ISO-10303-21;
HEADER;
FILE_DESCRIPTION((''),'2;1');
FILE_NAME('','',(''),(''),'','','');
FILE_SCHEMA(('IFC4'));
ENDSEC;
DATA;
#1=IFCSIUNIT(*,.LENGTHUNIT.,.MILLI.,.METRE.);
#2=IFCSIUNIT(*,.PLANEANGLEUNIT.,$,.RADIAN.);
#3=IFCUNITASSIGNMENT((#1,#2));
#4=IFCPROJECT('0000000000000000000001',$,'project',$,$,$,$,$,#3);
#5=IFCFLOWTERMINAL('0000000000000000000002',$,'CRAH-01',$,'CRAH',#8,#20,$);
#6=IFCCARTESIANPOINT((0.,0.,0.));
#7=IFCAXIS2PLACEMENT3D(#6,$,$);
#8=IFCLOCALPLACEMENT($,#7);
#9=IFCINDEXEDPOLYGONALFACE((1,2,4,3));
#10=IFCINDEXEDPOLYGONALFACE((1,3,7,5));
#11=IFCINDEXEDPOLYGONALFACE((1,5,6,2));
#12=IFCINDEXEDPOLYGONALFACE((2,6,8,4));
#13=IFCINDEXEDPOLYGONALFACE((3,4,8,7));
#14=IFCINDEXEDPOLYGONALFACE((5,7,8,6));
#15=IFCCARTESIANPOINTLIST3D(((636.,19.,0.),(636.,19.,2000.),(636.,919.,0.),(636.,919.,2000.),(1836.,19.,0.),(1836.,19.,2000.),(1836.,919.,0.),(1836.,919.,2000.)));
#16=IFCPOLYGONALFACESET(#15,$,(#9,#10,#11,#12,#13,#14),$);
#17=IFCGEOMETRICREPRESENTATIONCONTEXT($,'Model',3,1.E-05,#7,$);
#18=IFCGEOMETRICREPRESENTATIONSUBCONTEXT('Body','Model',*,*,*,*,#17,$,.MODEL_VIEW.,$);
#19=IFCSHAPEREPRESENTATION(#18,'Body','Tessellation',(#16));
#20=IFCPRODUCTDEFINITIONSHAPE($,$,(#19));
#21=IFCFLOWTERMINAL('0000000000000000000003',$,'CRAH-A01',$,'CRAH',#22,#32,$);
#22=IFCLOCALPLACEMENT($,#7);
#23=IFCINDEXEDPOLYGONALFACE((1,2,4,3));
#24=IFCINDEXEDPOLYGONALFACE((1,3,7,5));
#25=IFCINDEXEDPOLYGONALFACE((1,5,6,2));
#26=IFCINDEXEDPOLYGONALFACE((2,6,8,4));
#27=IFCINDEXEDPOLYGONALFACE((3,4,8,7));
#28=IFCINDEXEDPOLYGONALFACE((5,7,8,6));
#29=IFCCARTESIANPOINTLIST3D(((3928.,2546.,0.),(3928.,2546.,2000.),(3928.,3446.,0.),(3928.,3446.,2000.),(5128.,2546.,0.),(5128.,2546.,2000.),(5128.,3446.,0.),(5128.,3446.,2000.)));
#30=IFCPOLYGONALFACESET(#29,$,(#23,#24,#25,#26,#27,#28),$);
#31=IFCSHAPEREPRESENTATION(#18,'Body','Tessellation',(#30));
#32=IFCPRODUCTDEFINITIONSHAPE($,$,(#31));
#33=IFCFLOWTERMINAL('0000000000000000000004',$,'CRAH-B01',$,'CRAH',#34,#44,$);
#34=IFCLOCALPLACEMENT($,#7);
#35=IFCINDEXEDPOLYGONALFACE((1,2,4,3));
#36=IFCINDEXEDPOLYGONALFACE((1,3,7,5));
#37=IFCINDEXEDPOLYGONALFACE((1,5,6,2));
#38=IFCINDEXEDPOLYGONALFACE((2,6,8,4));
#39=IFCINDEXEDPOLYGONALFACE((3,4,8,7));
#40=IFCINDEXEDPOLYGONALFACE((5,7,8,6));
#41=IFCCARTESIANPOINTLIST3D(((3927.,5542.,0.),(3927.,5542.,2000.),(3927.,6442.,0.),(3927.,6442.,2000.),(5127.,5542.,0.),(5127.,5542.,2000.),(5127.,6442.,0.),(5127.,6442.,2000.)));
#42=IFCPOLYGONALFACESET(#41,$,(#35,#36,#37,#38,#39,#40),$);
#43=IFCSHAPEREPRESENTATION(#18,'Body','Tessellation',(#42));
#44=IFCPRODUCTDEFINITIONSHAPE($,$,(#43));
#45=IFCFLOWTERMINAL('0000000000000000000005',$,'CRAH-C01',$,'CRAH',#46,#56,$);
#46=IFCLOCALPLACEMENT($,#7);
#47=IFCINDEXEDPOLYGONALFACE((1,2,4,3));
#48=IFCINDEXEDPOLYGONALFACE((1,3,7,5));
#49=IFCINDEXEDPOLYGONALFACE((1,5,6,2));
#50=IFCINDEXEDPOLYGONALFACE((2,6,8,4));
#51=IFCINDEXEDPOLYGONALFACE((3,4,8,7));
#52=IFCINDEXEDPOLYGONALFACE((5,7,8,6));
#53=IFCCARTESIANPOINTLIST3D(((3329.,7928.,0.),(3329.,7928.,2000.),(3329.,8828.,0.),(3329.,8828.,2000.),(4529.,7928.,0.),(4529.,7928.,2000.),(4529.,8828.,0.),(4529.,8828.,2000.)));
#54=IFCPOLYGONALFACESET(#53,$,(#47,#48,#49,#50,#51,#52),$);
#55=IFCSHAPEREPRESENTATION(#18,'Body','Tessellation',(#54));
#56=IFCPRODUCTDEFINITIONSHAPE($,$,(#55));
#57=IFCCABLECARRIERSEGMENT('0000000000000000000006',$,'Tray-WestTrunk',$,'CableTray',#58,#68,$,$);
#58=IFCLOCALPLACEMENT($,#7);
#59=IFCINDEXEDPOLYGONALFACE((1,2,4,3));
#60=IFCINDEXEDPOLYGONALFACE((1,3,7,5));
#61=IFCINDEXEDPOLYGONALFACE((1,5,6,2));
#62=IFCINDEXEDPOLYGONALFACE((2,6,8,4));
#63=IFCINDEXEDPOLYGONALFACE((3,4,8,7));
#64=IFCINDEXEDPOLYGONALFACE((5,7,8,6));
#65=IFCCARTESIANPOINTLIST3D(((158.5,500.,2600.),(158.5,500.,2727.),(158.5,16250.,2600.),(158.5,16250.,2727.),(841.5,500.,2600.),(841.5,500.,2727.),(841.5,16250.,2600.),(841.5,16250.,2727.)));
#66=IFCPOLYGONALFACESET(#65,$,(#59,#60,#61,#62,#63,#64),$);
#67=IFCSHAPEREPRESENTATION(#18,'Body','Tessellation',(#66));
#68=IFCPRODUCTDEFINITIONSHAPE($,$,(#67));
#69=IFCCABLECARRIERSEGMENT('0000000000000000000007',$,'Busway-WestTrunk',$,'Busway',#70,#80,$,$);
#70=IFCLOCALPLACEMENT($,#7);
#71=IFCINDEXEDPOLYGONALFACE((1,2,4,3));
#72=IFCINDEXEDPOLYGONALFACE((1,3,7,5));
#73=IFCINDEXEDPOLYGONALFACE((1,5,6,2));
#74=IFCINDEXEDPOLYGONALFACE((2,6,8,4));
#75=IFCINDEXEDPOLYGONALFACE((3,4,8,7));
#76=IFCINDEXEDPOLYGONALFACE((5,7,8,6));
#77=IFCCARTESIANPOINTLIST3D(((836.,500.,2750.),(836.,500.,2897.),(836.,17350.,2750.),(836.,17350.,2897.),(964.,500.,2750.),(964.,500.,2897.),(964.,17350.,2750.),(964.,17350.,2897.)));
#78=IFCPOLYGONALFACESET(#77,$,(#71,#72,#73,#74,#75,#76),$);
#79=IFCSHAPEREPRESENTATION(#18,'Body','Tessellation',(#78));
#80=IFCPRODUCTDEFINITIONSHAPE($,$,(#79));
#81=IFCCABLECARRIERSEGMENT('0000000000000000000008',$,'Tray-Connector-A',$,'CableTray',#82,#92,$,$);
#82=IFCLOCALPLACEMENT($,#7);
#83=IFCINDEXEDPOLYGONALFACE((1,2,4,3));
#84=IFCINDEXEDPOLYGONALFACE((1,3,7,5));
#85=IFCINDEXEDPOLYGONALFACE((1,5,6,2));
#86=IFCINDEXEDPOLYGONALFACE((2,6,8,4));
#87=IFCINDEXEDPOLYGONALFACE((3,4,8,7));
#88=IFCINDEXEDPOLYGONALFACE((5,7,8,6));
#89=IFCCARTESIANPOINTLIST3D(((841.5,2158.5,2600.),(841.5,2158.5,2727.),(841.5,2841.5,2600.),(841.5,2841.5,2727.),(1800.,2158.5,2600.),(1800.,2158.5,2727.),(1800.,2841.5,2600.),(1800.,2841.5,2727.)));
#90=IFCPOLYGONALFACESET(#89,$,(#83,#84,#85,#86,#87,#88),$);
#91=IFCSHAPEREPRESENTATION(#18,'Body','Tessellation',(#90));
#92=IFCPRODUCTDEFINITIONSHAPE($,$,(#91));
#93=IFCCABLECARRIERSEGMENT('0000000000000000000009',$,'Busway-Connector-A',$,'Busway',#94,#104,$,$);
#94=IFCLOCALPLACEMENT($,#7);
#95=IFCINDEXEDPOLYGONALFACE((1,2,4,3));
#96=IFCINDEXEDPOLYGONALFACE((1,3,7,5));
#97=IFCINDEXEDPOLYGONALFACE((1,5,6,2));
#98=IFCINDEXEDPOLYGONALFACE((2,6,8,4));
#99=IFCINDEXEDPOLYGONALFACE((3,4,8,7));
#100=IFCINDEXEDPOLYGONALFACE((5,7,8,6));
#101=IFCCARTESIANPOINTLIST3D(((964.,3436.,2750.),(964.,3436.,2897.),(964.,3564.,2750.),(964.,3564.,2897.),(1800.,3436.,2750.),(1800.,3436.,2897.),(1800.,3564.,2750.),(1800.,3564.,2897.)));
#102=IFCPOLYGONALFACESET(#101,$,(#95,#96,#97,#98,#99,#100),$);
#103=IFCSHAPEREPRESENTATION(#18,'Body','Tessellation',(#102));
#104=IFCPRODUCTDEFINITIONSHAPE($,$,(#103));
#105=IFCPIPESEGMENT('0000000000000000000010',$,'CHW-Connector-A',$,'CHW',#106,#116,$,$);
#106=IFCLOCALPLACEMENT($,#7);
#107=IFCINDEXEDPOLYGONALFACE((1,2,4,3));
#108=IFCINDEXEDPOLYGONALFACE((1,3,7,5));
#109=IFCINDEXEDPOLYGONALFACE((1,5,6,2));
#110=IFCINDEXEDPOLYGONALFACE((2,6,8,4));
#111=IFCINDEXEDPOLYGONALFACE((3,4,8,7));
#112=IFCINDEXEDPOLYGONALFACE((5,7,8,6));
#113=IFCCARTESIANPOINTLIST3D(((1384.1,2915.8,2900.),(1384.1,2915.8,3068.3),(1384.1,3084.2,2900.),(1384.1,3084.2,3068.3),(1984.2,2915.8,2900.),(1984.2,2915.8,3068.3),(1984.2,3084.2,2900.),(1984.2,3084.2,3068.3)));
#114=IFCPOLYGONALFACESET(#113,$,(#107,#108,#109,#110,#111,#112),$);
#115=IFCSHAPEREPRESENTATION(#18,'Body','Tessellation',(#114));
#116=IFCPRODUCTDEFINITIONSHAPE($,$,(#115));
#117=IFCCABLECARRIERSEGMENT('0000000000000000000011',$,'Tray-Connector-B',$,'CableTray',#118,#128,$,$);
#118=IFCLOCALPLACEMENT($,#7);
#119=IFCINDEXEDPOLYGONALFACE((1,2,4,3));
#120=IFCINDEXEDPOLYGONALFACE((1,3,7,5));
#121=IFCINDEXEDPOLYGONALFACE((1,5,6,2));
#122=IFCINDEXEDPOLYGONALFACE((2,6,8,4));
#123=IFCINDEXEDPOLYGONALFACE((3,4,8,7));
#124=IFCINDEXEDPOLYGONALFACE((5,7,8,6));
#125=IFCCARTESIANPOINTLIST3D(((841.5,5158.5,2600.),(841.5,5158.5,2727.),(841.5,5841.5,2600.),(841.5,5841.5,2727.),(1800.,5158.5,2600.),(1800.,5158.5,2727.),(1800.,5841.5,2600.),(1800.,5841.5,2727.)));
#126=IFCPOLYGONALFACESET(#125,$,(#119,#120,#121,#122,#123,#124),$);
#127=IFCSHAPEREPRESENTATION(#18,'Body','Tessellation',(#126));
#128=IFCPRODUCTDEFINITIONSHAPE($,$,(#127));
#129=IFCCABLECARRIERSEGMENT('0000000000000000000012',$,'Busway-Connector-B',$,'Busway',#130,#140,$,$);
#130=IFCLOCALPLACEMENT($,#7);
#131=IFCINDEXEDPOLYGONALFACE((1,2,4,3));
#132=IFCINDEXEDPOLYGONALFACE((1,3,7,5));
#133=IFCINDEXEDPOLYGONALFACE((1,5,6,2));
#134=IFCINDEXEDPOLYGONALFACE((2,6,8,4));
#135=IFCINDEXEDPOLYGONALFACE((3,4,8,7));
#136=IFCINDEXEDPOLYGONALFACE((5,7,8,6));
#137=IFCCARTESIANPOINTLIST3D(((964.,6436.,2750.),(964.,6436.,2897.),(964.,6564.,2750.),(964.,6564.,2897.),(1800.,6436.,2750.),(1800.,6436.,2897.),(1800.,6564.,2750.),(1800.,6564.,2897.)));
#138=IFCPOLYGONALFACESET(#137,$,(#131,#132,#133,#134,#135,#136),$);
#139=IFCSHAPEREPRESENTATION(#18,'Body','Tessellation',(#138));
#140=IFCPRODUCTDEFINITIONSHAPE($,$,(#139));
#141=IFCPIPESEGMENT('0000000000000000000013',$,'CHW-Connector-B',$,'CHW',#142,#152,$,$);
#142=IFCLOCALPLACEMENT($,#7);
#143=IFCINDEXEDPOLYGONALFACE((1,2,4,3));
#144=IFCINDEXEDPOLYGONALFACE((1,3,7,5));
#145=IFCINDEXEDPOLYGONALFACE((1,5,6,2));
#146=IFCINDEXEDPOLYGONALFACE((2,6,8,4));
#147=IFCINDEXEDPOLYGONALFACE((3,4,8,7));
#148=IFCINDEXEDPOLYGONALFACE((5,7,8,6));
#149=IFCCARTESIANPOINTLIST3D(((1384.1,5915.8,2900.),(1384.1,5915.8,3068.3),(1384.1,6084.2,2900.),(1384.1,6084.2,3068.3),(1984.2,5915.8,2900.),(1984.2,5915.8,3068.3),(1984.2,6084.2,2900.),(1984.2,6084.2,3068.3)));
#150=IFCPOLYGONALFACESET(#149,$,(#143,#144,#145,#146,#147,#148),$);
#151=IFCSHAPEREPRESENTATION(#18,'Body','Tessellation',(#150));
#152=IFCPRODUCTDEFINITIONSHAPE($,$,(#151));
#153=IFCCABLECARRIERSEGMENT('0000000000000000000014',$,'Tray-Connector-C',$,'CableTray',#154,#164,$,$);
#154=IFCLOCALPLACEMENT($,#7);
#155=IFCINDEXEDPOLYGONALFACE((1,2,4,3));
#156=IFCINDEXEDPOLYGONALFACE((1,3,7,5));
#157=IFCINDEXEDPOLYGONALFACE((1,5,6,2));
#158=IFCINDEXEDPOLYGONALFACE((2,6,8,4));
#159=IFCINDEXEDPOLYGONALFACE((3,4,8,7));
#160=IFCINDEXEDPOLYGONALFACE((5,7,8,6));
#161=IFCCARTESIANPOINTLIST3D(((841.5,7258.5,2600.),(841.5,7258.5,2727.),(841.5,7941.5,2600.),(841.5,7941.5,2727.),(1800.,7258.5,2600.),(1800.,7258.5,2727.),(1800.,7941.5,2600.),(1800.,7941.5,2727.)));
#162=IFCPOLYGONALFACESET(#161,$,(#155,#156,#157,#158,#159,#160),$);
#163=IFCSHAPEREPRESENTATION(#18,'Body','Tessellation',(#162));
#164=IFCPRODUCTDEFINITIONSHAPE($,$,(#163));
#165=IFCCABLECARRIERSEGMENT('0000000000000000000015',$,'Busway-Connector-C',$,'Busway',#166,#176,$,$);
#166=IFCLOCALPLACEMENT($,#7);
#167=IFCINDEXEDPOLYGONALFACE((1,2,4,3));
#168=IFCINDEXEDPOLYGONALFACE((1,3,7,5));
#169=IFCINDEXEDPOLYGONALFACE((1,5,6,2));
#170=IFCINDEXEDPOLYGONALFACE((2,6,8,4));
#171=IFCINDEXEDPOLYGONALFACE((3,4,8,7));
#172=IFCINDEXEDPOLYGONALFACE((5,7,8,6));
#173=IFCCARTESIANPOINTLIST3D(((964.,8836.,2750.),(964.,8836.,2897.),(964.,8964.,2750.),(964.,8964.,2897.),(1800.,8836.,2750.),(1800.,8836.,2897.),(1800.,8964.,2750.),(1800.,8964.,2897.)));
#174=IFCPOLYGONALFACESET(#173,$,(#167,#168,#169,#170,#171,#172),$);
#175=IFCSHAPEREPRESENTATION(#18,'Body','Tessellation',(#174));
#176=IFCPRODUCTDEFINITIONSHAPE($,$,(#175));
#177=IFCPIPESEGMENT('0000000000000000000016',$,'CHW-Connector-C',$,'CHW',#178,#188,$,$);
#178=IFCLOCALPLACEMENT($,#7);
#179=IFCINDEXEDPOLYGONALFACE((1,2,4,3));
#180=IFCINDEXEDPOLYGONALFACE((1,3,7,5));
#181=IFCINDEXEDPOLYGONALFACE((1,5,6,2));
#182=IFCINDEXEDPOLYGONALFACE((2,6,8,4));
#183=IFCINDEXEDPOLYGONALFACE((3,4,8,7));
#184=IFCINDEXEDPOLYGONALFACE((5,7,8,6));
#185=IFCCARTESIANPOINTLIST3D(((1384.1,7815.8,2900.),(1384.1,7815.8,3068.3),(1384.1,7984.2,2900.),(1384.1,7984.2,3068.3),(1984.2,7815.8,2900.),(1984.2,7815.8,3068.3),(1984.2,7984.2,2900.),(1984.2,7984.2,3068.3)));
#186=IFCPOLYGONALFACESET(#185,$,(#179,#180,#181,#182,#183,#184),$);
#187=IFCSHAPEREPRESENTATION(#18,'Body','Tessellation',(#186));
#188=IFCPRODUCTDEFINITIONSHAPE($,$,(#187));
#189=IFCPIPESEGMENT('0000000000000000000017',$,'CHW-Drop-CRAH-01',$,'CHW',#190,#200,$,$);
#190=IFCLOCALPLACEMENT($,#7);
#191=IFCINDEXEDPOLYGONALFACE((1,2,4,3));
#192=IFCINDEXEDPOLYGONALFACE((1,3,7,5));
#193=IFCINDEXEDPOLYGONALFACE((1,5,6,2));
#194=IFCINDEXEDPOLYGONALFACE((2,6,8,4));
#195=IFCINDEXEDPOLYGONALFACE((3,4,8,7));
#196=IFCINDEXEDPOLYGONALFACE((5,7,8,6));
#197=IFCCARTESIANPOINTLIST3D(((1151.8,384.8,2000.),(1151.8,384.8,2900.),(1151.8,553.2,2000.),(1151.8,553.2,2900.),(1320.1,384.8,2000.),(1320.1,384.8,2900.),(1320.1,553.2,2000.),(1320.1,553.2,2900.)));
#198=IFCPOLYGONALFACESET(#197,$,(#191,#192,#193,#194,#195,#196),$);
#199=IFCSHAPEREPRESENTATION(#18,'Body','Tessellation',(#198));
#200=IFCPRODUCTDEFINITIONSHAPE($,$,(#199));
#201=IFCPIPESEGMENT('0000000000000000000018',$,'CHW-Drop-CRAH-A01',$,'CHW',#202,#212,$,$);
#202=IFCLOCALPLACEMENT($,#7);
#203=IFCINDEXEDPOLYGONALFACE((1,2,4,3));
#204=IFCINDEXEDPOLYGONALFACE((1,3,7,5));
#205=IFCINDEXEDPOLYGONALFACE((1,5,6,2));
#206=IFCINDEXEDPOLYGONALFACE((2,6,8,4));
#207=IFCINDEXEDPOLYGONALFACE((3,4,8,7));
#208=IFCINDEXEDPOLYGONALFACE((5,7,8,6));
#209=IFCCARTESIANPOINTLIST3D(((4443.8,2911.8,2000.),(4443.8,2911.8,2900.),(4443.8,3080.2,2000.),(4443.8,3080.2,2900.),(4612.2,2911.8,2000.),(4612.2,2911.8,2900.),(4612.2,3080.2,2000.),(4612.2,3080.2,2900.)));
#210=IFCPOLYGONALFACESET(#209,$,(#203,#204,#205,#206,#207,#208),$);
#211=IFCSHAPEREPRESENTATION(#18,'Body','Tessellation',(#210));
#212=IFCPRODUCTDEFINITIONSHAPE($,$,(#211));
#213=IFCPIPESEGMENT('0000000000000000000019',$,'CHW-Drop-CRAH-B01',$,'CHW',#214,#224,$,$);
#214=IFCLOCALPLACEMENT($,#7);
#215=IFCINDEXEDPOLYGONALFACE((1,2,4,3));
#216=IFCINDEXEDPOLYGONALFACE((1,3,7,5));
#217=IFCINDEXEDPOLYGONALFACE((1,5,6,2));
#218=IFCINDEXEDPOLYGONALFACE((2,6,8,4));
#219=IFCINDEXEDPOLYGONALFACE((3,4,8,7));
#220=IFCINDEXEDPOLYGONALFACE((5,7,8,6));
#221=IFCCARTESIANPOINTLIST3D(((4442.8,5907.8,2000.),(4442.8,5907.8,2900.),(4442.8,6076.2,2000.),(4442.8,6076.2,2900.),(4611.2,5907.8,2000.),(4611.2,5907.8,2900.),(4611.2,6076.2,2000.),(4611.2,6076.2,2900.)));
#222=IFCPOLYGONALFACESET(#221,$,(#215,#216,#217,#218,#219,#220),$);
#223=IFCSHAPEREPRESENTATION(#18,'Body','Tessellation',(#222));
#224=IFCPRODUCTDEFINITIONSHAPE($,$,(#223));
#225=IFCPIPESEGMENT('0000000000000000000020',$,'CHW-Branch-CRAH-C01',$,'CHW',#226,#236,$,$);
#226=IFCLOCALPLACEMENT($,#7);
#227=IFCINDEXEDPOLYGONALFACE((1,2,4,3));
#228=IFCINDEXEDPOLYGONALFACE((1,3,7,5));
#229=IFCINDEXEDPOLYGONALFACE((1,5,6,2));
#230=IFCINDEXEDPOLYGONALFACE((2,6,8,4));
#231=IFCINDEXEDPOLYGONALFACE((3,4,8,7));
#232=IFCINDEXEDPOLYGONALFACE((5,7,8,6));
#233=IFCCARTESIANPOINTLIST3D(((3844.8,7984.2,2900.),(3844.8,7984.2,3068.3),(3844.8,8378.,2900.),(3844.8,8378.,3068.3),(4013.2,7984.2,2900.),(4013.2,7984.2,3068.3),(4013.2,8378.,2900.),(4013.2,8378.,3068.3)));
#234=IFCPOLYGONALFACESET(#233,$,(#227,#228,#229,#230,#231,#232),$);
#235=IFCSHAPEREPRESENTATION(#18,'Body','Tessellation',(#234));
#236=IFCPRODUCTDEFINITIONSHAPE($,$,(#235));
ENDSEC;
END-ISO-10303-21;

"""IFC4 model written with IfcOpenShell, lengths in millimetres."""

from ifc_helpers import new_model, si_unit, frame, origin, place, context, subcontext, project, rectangle, extrude, element, save


model = new_model("IFC4")

# Units and contexts
model_context = context("Model", 3, precision=1e-05, world=origin())
body_context = subcontext(model_context, "Body", "Model", "MODEL_VIEW")
ifc_project = project(units=[si_unit("LENGTHUNIT", "METRE", prefix="MILLI"), si_unit("PLANEANGLEUNIT", "RADIAN")])

# Flow terminals
for number, where, name in (
    (1, (1236.0, 469.0, 0.0), "CRAH-01"),
    (2, (4528.0, 2996.0, 0.0), "CRAH-A01"),
    (3, (4527.0, 5992.0, 0.0), "CRAH-B01"),
    (4, (3929.0, 8378.0, 0.0), "CRAH-C01"),
):
    element("IfcFlowTerminal", number, at=place(None, frame(where)), Name=name, ObjectType="CRAH", context=body_context, shape_type="SweptSolid", body=[
        extrude(rectangle(XDim=1200.0, YDim=900.0), None, (0.0, 0.0, 1.0), 2000.0),
    ])

# Cable carrier segments
cable_carrier_segment_1_placement = place(None, frame((500.0, 8375.0, 2600.0)))
element("IfcCableCarrierSegment", 5, at=cable_carrier_segment_1_placement, Name="Tray-WestTrunk", ObjectType="CableTray", context=body_context, shape_type="SweptSolid", body=[
    extrude(rectangle(XDim=683.0, YDim=15750.0), None, (0.0, 0.0, 1.0), 127.0),
])
cable_carrier_segment_2_placement = place(None, frame((900.0, 8925.0, 2750.0)))
element("IfcCableCarrierSegment", 6, at=cable_carrier_segment_2_placement, Name="Busway-WestTrunk", ObjectType="Busway", context=body_context, shape_type="SweptSolid", body=[
    extrude(rectangle(XDim=128.0, YDim=16850.0), None, (0.0, 0.0, 1.0), 147.0),
])
cable_carrier_segment_3_placement = place(None, frame((1320.8, 2500.0, 2600.0)))
element("IfcCableCarrierSegment", 7, at=cable_carrier_segment_3_placement, Name="Tray-Connector-A", ObjectType="CableTray", context=body_context, shape_type="SweptSolid", body=[
    extrude(rectangle(XDim=958.5, YDim=683.0), None, (0.0, 0.0, 1.0), 127.0),
])
cable_carrier_segment_4_placement = place(None, frame((1382.0, 3500.0, 2750.0)))
element("IfcCableCarrierSegment", 8, at=cable_carrier_segment_4_placement, Name="Busway-Connector-A", ObjectType="Busway", context=body_context, shape_type="SweptSolid", body=[
    extrude(rectangle(XDim=836.0, YDim=128.0), None, (0.0, 0.0, 1.0), 147.0),
])

# Pipe segment
pipe_segment_1_placement = place(None, frame((1684.2, 3000.0, 2900.0)))
element("IfcPipeSegment", 9, at=pipe_segment_1_placement, Name="CHW-Connector-A", ObjectType="CHW", context=body_context, shape_type="SweptSolid", body=[
    extrude(rectangle(XDim=600.0, YDim=168.3), None, (0.0, 0.0, 1.0), 168.3),
])

# Cable carrier segments
cable_carrier_segment_5_placement = place(None, frame((1320.8, 5500.0, 2600.0)))
element("IfcCableCarrierSegment", 10, at=cable_carrier_segment_5_placement, Name="Tray-Connector-B", ObjectType="CableTray", context=body_context, shape_type="SweptSolid", body=[
    extrude(rectangle(XDim=958.5, YDim=683.0), None, (0.0, 0.0, 1.0), 127.0),
])
cable_carrier_segment_6_placement = place(None, frame((1382.0, 6500.0, 2750.0)))
element("IfcCableCarrierSegment", 11, at=cable_carrier_segment_6_placement, Name="Busway-Connector-B", ObjectType="Busway", context=body_context, shape_type="SweptSolid", body=[
    extrude(rectangle(XDim=836.0, YDim=128.0), None, (0.0, 0.0, 1.0), 147.0),
])

# Pipe segment
pipe_segment_2_placement = place(None, frame((1684.2, 6000.0, 2900.0)))
element("IfcPipeSegment", 12, at=pipe_segment_2_placement, Name="CHW-Connector-B", ObjectType="CHW", context=body_context, shape_type="SweptSolid", body=[
    extrude(rectangle(XDim=600.0, YDim=168.3), None, (0.0, 0.0, 1.0), 168.3),
])

# Cable carrier segments
cable_carrier_segment_7_placement = place(None, frame((1320.8, 7600.0, 2600.0)))
element("IfcCableCarrierSegment", 13, at=cable_carrier_segment_7_placement, Name="Tray-Connector-C", ObjectType="CableTray", context=body_context, shape_type="SweptSolid", body=[
    extrude(rectangle(XDim=958.5, YDim=683.0), None, (0.0, 0.0, 1.0), 127.0),
])
cable_carrier_segment_8_placement = place(None, frame((1382.0, 8900.0, 2750.0)))
element("IfcCableCarrierSegment", 14, at=cable_carrier_segment_8_placement, Name="Busway-Connector-C", ObjectType="Busway", context=body_context, shape_type="SweptSolid", body=[
    extrude(rectangle(XDim=836.0, YDim=128.0), None, (0.0, 0.0, 1.0), 147.0),
])

# Pipe segments
pipe_segment_3_placement = place(None, frame((1684.2, 7900.0, 2900.0)))
element("IfcPipeSegment", 15, at=pipe_segment_3_placement, Name="CHW-Connector-C", ObjectType="CHW", context=body_context, shape_type="SweptSolid", body=[
    extrude(rectangle(XDim=600.0, YDim=168.3), None, (0.0, 0.0, 1.0), 168.3),
])
for number, where, name in (
    (16, (1236.0, 469.0, 2000.0), "CHW-Drop-CRAH-01"),
    (17, (4528.0, 2996.0, 2000.0), "CHW-Drop-CRAH-A01"),
    (18, (4527.0, 5992.0, 2000.0), "CHW-Drop-CRAH-B01"),
):
    element("IfcPipeSegment", number, at=place(None, frame(where)), Name=name, ObjectType="CHW", context=body_context, shape_type="SweptSolid", body=[
        extrude(rectangle(XDim=168.3, YDim=168.3), None, (0.0, 0.0, 1.0), 900.0),
    ])
pipe_segment_4_placement = place(None, frame((3929.0, 8181.1, 2900.0)))
element("IfcPipeSegment", 19, at=pipe_segment_4_placement, Name="CHW-Branch-CRAH-C01", ObjectType="CHW", context=body_context, shape_type="SweptSolid", body=[
    extrude(rectangle(XDim=168.3, YDim=393.9), None, (0.0, 0.0, 1.0), 168.3),
])

save(model, "model.ifc")
